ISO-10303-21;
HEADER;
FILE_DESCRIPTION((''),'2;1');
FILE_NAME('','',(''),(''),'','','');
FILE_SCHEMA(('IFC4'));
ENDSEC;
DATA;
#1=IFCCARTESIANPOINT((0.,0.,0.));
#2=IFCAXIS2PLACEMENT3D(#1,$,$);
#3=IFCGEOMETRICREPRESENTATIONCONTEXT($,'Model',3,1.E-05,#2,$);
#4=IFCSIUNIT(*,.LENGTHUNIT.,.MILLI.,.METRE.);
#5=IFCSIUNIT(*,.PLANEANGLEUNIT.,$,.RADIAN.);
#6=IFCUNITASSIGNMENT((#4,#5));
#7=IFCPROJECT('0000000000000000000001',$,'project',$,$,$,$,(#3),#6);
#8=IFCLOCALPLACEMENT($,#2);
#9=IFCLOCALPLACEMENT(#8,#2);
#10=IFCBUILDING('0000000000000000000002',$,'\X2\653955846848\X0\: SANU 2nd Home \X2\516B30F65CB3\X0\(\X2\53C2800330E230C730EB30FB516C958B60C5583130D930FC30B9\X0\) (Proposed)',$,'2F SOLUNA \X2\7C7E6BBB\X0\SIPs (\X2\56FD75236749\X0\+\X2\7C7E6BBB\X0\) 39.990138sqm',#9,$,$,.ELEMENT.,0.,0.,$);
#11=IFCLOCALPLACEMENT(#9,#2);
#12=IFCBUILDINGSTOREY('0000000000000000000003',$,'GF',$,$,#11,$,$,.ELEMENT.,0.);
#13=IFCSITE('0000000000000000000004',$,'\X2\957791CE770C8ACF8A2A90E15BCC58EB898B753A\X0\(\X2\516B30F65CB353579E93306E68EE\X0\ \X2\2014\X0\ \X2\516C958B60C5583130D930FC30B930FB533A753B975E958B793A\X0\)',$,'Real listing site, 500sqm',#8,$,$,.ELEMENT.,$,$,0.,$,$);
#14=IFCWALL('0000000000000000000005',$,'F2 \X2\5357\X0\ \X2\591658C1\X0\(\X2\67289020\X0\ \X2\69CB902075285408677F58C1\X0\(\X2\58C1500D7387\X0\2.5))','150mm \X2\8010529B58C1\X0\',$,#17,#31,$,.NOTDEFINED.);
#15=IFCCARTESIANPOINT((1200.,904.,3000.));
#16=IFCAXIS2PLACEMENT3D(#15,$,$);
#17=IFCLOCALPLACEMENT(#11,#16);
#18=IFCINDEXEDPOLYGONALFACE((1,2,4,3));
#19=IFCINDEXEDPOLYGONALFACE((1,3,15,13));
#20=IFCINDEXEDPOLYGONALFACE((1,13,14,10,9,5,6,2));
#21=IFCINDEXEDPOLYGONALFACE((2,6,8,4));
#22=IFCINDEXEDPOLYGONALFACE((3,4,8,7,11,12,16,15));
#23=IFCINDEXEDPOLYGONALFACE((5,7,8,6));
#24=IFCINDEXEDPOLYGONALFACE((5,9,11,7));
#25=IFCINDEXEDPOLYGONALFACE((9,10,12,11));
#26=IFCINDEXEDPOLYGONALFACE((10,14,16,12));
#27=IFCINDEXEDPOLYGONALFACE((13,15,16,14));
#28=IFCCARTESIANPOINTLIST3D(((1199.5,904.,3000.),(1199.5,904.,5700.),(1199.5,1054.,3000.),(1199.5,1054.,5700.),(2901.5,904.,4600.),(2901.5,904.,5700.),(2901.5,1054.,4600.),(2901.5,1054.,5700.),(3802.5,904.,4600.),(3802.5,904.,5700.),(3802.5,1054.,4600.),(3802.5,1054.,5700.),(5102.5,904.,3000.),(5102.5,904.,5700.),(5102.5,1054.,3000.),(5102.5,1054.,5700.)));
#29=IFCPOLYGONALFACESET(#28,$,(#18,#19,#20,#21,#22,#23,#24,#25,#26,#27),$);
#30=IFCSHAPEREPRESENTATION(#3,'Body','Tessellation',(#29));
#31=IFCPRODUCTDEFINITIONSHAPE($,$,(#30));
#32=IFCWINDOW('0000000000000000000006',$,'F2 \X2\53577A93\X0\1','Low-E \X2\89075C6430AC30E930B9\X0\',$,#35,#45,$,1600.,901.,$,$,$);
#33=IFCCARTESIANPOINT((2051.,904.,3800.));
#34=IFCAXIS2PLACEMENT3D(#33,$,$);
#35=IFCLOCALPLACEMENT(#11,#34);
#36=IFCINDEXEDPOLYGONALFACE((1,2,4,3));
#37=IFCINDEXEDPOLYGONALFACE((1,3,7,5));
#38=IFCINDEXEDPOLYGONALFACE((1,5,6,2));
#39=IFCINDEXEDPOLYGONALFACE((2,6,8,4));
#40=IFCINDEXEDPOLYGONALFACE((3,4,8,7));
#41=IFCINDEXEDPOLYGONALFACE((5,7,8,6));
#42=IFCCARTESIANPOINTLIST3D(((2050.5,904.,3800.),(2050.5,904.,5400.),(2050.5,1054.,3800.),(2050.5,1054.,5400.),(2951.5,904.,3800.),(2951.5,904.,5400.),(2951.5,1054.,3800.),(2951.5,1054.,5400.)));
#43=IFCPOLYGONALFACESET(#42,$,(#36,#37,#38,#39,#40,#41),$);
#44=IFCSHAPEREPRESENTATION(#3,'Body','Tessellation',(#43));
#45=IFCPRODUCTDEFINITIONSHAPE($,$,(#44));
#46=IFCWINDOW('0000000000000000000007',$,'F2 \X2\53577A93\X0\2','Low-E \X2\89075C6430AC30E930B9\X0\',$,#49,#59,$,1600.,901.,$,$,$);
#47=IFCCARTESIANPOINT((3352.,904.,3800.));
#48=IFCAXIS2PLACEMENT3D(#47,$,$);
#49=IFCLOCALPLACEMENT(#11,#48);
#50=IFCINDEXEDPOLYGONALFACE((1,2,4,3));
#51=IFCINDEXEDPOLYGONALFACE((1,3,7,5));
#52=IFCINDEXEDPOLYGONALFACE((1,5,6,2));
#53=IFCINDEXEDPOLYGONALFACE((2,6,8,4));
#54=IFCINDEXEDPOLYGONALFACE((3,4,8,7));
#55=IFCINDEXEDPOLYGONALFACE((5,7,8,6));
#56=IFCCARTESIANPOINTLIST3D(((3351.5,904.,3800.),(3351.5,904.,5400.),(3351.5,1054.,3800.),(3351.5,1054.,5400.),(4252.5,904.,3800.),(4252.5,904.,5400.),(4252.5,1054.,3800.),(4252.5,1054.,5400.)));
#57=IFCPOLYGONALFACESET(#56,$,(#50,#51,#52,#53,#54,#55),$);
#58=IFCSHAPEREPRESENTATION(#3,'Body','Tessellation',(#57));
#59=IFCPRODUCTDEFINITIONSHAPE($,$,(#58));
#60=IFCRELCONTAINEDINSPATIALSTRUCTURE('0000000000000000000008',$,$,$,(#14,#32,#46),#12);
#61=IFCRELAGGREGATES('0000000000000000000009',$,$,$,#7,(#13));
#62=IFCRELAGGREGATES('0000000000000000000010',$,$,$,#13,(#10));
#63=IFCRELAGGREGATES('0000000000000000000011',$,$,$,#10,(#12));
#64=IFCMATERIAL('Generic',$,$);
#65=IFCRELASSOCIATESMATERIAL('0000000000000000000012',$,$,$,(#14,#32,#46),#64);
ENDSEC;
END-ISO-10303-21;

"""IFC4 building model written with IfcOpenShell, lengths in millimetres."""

from ifc_helpers import new_model, si_unit, frame, frame_2d, origin, place, context, project, spatial, rectangle, extrude, material, element, fill, save


model = new_model("IFC4")

# Units and contexts
model_context = context("Model", 3, precision=1e-05, world=origin())
ifc_project = project(units=[si_unit("LENGTHUNIT", "METRE", prefix="MILLI"), si_unit("PLANEANGLEUNIT", "RADIAN")], contexts=[model_context])

# Site, building, storey
site_placement = place(None, origin())
site = spatial("IfcSite", under=ifc_project, at=site_placement, Name="長野県諏訪郡富士見町(八ヶ岳南麓の森 — 公開情報ベース・区画非開示)", ObjectType="Real listing site, 500sqm", CompositionType="ELEMENT", RefElevation=0.0)
building_placement = place(site_placement, origin())
building = spatial("IfcBuilding", under=site, at=building_placement, Name="改善案: SANU 2nd Home 八ヶ岳(参考モデル・公開情報ベース) (Proposed)", ObjectType="2F SOLUNA 籾殻SIPs (国産杉+籾殻) 39.990138sqm", CompositionType="ELEMENT", ElevationOfRefHeight=0.0, ElevationOfTerrain=0.0)
storey_placement = place(building_placement, origin())
storey = spatial("IfcBuildingStorey", under=building, at=storey_placement, Name="GF", CompositionType="ELEMENT", Elevation=0.0)

# Shared definitions
ifc_material_1 = material(Name="Generic")

# Wall, openings, windows
wall_1_placement = place(storey_placement, frame((1200.0, 904.0, 3000.0)))
wall_1 = element("IfcWall", 1, at=wall_1_placement, inside=storey, material=ifc_material_1, Name="F2 南 外壁(木造 構造用合板壁(壁倍率2.5))", Description="150mm 耐力壁", PredefinedType="NOTDEFINED", context=model_context, shape_type="SweptSolid", body=[
    extrude(rectangle(XDim=3903.0, YDim=150.0, at=frame_2d((1951.0, 75.0))), frame((1200.0, 904.0, 3000.0)), (0.0, 0.0, 1.0), 2700.0),
])
opening_1_placement = place(storey_placement, frame((2051.0, 904.0, 3800.0)))
opening_1 = element("IfcOpeningElement", 2, at=opening_1_placement, cuts=wall_1, PredefinedType="NOTDEFINED", context=model_context, shape_type="SweptSolid", body=[
    extrude(rectangle(XDim=901.0, YDim=150.0, at=frame_2d((450.0, 75.0))), frame((2051.0, 904.0, 3800.0)), (0.0, 0.0, 1.0), 1600.0),
])
opening_2_placement = place(storey_placement, frame((3352.0, 904.0, 3800.0)))
opening_2 = element("IfcOpeningElement", 3, at=opening_2_placement, cuts=wall_1, PredefinedType="NOTDEFINED", context=model_context, shape_type="SweptSolid", body=[
    extrude(rectangle(XDim=901.0, YDim=150.0, at=frame_2d((450.0, 75.0))), frame((3352.0, 904.0, 3800.0)), (0.0, 0.0, 1.0), 1600.0),
])
window_1_placement = place(storey_placement, frame((2051.0, 904.0, 3800.0)))
window_1 = element("IfcWindow", 4, at=window_1_placement, inside=storey, material=ifc_material_1, Name="F2 南窓1", Description="Low-E 複層ガラス", OverallHeight=1600.0, OverallWidth=901.0, context=model_context, shape_type="SweptSolid", body=[
    extrude(rectangle(XDim=901.0, YDim=150.0, at=frame_2d((450.0, 75.0))), frame((2051.0, 904.0, 3800.0)), (0.0, 0.0, 1.0), 1600.0),
])
fill(opening_1, window_1)
window_2_placement = place(storey_placement, frame((3352.0, 904.0, 3800.0)))
window_2 = element("IfcWindow", 5, at=window_2_placement, inside=storey, material=ifc_material_1, Name="F2 南窓2", Description="Low-E 複層ガラス", OverallHeight=1600.0, OverallWidth=901.0, context=model_context, shape_type="SweptSolid", body=[
    extrude(rectangle(XDim=901.0, YDim=150.0, at=frame_2d((450.0, 75.0))), frame((3352.0, 904.0, 3800.0)), (0.0, 0.0, 1.0), 1600.0),
])
fill(opening_2, window_2)

save(model, "model.ifc")
